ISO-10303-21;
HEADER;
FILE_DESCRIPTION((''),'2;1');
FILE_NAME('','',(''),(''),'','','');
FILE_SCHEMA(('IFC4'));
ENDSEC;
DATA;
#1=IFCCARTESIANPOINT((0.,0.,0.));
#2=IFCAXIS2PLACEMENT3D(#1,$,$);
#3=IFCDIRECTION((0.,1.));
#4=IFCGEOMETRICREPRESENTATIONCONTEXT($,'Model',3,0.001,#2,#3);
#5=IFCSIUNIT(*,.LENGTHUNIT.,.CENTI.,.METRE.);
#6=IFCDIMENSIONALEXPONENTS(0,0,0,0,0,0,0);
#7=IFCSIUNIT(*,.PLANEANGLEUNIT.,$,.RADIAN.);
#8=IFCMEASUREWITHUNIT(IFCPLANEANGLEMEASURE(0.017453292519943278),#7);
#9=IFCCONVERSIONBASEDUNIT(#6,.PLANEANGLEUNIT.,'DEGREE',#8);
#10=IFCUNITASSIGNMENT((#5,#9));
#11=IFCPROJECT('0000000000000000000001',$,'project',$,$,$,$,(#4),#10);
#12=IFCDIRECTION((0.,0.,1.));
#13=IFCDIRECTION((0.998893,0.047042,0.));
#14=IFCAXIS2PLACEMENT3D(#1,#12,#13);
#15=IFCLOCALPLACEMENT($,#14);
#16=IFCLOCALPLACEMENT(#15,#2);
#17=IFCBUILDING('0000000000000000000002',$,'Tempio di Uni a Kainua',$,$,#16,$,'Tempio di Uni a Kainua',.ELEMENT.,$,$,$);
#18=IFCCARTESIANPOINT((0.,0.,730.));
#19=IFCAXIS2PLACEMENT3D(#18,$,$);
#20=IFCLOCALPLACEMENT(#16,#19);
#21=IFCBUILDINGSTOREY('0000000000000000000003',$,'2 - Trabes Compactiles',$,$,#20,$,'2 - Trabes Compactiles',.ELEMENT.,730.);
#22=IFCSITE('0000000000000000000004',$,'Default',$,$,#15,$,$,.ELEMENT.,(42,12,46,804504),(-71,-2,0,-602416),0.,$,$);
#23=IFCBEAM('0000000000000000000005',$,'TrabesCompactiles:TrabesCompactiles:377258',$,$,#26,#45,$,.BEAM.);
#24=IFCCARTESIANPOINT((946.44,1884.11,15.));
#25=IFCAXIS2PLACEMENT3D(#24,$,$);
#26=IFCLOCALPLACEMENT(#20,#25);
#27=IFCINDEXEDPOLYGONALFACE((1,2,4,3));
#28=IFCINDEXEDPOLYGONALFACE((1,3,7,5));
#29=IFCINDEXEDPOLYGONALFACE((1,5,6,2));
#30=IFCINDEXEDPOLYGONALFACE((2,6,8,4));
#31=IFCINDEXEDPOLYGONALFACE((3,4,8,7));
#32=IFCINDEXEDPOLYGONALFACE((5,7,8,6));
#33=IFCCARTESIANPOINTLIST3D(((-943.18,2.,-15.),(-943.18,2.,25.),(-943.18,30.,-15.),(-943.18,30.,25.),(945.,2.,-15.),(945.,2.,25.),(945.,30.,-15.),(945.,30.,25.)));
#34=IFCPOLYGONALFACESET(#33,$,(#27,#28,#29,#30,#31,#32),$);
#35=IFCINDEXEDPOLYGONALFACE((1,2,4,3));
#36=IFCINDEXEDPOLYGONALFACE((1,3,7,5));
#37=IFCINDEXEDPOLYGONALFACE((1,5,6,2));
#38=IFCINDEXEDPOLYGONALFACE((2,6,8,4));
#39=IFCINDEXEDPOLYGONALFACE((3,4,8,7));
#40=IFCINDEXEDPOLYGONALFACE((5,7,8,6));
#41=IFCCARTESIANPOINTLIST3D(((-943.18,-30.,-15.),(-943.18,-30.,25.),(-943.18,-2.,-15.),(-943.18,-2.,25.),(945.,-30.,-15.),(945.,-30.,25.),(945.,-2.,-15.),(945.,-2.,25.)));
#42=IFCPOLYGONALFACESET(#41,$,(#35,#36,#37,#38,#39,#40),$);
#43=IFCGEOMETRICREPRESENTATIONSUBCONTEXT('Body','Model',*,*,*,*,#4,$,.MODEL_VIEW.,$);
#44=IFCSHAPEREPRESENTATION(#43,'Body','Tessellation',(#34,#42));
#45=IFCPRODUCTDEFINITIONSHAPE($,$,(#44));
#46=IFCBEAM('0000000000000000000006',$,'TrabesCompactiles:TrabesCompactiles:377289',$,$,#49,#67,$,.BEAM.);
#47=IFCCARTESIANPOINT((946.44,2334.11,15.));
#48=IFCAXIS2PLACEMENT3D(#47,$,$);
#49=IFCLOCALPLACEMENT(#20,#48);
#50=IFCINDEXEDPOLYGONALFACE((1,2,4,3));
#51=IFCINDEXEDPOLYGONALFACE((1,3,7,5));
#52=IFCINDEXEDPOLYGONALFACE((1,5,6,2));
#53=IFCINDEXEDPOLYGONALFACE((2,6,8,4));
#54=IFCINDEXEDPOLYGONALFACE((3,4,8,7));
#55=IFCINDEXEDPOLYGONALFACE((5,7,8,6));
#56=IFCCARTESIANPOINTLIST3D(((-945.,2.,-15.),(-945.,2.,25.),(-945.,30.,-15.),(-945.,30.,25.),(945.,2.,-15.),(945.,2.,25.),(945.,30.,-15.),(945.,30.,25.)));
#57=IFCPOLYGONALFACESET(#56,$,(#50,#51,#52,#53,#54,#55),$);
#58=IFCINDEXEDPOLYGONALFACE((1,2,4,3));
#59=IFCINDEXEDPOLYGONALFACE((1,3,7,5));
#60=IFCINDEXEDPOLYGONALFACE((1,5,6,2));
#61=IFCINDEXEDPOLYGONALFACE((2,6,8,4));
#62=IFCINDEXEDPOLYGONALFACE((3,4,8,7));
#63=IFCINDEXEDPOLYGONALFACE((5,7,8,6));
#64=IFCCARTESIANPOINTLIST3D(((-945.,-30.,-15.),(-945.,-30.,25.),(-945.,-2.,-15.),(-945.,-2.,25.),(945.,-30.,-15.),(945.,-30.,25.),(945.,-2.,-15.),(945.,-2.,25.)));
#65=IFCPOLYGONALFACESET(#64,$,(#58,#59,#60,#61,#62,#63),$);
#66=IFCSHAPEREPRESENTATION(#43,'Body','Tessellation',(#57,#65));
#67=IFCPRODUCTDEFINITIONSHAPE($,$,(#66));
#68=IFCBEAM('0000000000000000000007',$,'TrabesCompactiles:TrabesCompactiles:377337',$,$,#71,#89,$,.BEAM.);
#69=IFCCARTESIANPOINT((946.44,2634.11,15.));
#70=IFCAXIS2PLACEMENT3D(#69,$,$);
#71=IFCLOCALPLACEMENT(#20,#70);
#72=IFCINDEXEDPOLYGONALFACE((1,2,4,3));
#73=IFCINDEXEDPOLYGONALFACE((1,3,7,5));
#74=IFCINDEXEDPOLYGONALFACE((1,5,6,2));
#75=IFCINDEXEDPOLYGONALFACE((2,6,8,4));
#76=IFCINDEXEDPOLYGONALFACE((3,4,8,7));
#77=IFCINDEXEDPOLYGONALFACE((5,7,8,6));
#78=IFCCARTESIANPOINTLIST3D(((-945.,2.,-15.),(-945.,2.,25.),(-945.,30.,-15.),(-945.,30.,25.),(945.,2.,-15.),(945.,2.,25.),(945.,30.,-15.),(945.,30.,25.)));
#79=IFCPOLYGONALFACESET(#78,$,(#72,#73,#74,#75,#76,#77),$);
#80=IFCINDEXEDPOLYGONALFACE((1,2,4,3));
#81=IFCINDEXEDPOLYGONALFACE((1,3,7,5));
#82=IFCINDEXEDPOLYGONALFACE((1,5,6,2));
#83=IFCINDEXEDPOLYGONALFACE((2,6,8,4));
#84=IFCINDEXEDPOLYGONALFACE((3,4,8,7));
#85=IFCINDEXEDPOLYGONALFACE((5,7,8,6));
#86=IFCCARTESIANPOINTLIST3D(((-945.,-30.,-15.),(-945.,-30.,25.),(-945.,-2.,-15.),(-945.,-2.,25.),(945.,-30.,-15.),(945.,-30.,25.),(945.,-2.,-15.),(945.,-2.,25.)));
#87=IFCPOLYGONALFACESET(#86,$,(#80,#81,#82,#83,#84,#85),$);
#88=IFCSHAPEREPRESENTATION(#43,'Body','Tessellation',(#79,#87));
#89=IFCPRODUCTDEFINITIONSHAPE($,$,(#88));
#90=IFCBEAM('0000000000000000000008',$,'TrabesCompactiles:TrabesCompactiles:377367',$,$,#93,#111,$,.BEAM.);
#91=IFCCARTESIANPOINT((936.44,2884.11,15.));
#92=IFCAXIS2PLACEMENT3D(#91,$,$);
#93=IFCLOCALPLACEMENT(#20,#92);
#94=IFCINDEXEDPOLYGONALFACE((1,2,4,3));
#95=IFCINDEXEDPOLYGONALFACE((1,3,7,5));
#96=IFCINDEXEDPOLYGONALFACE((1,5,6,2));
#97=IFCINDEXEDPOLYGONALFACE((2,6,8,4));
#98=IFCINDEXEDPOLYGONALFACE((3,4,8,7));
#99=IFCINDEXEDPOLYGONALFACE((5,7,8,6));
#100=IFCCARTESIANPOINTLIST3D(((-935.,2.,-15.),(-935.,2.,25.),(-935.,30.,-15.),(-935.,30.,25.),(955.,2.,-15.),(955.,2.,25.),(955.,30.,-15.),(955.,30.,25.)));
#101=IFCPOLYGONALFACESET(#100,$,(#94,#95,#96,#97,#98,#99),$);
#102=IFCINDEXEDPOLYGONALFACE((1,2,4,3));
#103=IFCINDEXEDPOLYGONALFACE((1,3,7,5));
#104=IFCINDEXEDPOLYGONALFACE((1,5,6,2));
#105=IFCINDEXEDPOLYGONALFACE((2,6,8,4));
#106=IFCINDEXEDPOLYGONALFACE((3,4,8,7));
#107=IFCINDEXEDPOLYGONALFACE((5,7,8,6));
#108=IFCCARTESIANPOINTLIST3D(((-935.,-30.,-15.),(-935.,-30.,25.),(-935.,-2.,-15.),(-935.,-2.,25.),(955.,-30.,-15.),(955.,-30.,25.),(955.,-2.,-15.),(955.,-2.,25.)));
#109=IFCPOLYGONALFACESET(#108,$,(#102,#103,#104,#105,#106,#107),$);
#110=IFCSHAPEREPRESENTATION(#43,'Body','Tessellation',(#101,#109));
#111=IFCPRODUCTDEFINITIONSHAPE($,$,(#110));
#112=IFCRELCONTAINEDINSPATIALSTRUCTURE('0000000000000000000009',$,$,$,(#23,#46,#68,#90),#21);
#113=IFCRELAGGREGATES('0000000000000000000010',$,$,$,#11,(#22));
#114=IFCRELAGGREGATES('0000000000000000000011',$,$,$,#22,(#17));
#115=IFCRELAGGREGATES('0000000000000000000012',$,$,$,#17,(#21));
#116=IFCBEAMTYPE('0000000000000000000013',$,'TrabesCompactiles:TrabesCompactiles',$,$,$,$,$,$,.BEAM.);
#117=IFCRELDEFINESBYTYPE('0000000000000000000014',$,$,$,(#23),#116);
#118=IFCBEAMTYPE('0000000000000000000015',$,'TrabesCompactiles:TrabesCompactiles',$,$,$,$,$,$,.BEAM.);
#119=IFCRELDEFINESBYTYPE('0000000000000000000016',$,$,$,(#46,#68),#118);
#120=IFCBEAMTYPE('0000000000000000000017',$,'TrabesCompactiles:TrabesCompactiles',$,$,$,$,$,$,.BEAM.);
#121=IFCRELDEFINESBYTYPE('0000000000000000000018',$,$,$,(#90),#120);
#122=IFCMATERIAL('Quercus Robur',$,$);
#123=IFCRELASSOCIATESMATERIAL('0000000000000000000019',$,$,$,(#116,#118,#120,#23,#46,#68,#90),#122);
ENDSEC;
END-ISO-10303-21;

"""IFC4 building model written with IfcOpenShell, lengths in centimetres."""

from ifc_helpers import new_model, entity, si_unit, converted_unit, direction, frame, frame_2d, origin, origin_2d_with_axis, place, context, subcontext, project, spatial, rectangle, extrude, source, transform, mapped, material, material_profile, profile_set, profile_usage, type_object, type_shapes, element, save


model = new_model("IFC4")

# Units and contexts
model_context = context("Model", 3, precision=0.001, world=origin(), true_north=direction((0.0, 1.0)))
body_context = subcontext(model_context, "Body", "Model", "MODEL_VIEW")
ifc_project = project(units=[si_unit("LENGTHUNIT", "METRE", prefix="CENTI"), converted_unit("PLANEANGLEUNIT", "DEGREE", entity("IfcPlaneAngleMeasure", 0.017453292519943278), si_unit("PLANEANGLEUNIT", "RADIAN"), dimensions=[0, 0, 0, 0, 0, 0, 0])], contexts=[model_context])

# Site, building, storey
site_placement = place(None, frame((0.0, 0.0, 0.0), z_axis=(0.0, 0.0, 1.0), x_axis=(0.998893, 0.047042, 0.0)))
site = spatial("IfcSite", under=ifc_project, at=site_placement, Name="Default", CompositionType="ELEMENT", RefLatitude=(42, 12, 46, 804504), RefLongitude=(-71, -2, 0, -602416), RefElevation=0.0)
building_placement = place(site_placement, origin())
building = spatial("IfcBuilding", under=site, at=building_placement, Name="Tempio di Uni a Kainua", LongName="Tempio di Uni a Kainua", CompositionType="ELEMENT")
storey_placement = place(building_placement, frame((0.0, 0.0, 730.0)))
storey = spatial("IfcBuildingStorey", under=building, at=storey_placement, Name="2 - Trabes Compactiles", LongName="2 - Trabes Compactiles", CompositionType="ELEMENT", Elevation=730.0)

# Beams
ifc_material = material(Name="Quercus Robur")
ifc_material_profile_1 = material_profile(ifc_material, rectangle(XDim=1937.89, YDim=28.0, at=origin_2d_with_axis()), Name="TrabesCompactiles")
ifc_material_profile_2 = material_profile(ifc_material, rectangle(XDim=1937.89, YDim=28.0, at=frame_2d((0.0, 0.0), x_axis=(1.0, 0.0))), Name="TrabesCompactiles")
ifc_profile_set_1 = profile_set([ifc_material_profile_1, ifc_material_profile_2], Name="TrabesCompactiles")
ifc_profile_usage_1 = profile_usage(ifc_profile_set_1, cardinal=8)
beam_type_1 = type_object("IfcBeamType", Name="TrabesCompactiles:TrabesCompactiles", PredefinedType="BEAM", material=ifc_profile_set_1)
shared_shape_1 = source(origin(), body_context, "Body", "SweptSolid", [
    extrude(rectangle(XDim=1888.18, YDim=28.0, at=origin_2d_with_axis()), frame((0.91, 16.0, -15.0), z_axis=(0.0, 0.0, 1.0), x_axis=(-1.0, 0.0, 0.0)), (0.0, 0.0, 1.0), 40.0),
    extrude(rectangle(XDim=1888.18, YDim=28.0, at=frame_2d((0.0, 0.0), x_axis=(1.0, 0.0))), frame((0.91, -16.0, -15.0), z_axis=(0.0, 0.0, 1.0), x_axis=(-1.0, 0.0, 0.0)), (0.0, 0.0, 1.0), 40.0),
])
type_shapes(beam_type_1, [shared_shape_1])
beam_1_placement = place(storey_placement, frame((946.44, 1884.11, 15.0)))
element("IfcBeam", 1, at=beam_1_placement, inside=storey, type_object=beam_type_1, material=ifc_profile_usage_1, Name="TrabesCompactiles:TrabesCompactiles:377258", PredefinedType="BEAM", context=body_context, shape_type="MappedRepresentation", body=[
    mapped(shared_shape_1, transform((0.0, 0.0, 0.0), scale=1.0)),
])
beam_type_2 = type_object("IfcBeamType", Name="TrabesCompactiles:TrabesCompactiles", PredefinedType="BEAM", material=ifc_profile_set_1)
shared_shape_2 = source(origin(), body_context, "Body", "SweptSolid", [
    extrude(rectangle(XDim=1890.0, YDim=28.0, at=origin_2d_with_axis()), frame((0.0, 16.0, -15.0), z_axis=(0.0, 0.0, 1.0), x_axis=(-1.0, 0.0, 0.0)), (0.0, 0.0, 1.0), 40.0),
    extrude(rectangle(XDim=1890.0, YDim=28.0, at=frame_2d((0.0, 0.0), x_axis=(1.0, 0.0))), frame((0.0, -16.0, -15.0), z_axis=(0.0, 0.0, 1.0), x_axis=(-1.0, 0.0, 0.0)), (0.0, 0.0, 1.0), 40.0),
])
type_shapes(beam_type_2, [shared_shape_2])
for number, where, name in (
    (2, (946.44, 2334.11, 15.0), "TrabesCompactiles:TrabesCompactiles:377289"),
    (3, (946.44, 2634.11, 15.0), "TrabesCompactiles:TrabesCompactiles:377337"),
):
    element("IfcBeam", number, at=place(storey_placement, frame(where)), inside=storey, type_object=beam_type_2, material=ifc_profile_usage_1, Name=name, PredefinedType="BEAM", context=body_context, shape_type="MappedRepresentation", body=[
        mapped(shared_shape_2, transform((0.0, 0.0, 0.0), scale=1.0)),
    ])
beam_type_3 = type_object("IfcBeamType", Name="TrabesCompactiles:TrabesCompactiles", PredefinedType="BEAM", material=ifc_profile_set_1)
shared_shape_3 = source(origin(), body_context, "Body", "SweptSolid", [
    extrude(rectangle(XDim=1890.0, YDim=28.0, at=origin_2d_with_axis()), frame((10.0, 16.0, -15.0), z_axis=(0.0, 0.0, 1.0), x_axis=(-1.0, 0.0, 0.0)), (0.0, 0.0, 1.0), 40.0),
    extrude(rectangle(XDim=1890.0, YDim=28.0, at=frame_2d((0.0, 0.0), x_axis=(1.0, 0.0))), frame((10.0, -16.0, -15.0), z_axis=(0.0, 0.0, 1.0), x_axis=(-1.0, 0.0, 0.0)), (0.0, 0.0, 1.0), 40.0),
])
type_shapes(beam_type_3, [shared_shape_3])
beam_2_placement = place(storey_placement, frame((936.44, 2884.11, 15.0)))
element("IfcBeam", 4, at=beam_2_placement, inside=storey, type_object=beam_type_3, material=ifc_profile_usage_1, Name="TrabesCompactiles:TrabesCompactiles:377367", PredefinedType="BEAM", context=body_context, shape_type="MappedRepresentation", body=[
    mapped(shared_shape_3, transform((0.0, 0.0, 0.0), scale=1.0)),
])

save(model, "model.ifc")
